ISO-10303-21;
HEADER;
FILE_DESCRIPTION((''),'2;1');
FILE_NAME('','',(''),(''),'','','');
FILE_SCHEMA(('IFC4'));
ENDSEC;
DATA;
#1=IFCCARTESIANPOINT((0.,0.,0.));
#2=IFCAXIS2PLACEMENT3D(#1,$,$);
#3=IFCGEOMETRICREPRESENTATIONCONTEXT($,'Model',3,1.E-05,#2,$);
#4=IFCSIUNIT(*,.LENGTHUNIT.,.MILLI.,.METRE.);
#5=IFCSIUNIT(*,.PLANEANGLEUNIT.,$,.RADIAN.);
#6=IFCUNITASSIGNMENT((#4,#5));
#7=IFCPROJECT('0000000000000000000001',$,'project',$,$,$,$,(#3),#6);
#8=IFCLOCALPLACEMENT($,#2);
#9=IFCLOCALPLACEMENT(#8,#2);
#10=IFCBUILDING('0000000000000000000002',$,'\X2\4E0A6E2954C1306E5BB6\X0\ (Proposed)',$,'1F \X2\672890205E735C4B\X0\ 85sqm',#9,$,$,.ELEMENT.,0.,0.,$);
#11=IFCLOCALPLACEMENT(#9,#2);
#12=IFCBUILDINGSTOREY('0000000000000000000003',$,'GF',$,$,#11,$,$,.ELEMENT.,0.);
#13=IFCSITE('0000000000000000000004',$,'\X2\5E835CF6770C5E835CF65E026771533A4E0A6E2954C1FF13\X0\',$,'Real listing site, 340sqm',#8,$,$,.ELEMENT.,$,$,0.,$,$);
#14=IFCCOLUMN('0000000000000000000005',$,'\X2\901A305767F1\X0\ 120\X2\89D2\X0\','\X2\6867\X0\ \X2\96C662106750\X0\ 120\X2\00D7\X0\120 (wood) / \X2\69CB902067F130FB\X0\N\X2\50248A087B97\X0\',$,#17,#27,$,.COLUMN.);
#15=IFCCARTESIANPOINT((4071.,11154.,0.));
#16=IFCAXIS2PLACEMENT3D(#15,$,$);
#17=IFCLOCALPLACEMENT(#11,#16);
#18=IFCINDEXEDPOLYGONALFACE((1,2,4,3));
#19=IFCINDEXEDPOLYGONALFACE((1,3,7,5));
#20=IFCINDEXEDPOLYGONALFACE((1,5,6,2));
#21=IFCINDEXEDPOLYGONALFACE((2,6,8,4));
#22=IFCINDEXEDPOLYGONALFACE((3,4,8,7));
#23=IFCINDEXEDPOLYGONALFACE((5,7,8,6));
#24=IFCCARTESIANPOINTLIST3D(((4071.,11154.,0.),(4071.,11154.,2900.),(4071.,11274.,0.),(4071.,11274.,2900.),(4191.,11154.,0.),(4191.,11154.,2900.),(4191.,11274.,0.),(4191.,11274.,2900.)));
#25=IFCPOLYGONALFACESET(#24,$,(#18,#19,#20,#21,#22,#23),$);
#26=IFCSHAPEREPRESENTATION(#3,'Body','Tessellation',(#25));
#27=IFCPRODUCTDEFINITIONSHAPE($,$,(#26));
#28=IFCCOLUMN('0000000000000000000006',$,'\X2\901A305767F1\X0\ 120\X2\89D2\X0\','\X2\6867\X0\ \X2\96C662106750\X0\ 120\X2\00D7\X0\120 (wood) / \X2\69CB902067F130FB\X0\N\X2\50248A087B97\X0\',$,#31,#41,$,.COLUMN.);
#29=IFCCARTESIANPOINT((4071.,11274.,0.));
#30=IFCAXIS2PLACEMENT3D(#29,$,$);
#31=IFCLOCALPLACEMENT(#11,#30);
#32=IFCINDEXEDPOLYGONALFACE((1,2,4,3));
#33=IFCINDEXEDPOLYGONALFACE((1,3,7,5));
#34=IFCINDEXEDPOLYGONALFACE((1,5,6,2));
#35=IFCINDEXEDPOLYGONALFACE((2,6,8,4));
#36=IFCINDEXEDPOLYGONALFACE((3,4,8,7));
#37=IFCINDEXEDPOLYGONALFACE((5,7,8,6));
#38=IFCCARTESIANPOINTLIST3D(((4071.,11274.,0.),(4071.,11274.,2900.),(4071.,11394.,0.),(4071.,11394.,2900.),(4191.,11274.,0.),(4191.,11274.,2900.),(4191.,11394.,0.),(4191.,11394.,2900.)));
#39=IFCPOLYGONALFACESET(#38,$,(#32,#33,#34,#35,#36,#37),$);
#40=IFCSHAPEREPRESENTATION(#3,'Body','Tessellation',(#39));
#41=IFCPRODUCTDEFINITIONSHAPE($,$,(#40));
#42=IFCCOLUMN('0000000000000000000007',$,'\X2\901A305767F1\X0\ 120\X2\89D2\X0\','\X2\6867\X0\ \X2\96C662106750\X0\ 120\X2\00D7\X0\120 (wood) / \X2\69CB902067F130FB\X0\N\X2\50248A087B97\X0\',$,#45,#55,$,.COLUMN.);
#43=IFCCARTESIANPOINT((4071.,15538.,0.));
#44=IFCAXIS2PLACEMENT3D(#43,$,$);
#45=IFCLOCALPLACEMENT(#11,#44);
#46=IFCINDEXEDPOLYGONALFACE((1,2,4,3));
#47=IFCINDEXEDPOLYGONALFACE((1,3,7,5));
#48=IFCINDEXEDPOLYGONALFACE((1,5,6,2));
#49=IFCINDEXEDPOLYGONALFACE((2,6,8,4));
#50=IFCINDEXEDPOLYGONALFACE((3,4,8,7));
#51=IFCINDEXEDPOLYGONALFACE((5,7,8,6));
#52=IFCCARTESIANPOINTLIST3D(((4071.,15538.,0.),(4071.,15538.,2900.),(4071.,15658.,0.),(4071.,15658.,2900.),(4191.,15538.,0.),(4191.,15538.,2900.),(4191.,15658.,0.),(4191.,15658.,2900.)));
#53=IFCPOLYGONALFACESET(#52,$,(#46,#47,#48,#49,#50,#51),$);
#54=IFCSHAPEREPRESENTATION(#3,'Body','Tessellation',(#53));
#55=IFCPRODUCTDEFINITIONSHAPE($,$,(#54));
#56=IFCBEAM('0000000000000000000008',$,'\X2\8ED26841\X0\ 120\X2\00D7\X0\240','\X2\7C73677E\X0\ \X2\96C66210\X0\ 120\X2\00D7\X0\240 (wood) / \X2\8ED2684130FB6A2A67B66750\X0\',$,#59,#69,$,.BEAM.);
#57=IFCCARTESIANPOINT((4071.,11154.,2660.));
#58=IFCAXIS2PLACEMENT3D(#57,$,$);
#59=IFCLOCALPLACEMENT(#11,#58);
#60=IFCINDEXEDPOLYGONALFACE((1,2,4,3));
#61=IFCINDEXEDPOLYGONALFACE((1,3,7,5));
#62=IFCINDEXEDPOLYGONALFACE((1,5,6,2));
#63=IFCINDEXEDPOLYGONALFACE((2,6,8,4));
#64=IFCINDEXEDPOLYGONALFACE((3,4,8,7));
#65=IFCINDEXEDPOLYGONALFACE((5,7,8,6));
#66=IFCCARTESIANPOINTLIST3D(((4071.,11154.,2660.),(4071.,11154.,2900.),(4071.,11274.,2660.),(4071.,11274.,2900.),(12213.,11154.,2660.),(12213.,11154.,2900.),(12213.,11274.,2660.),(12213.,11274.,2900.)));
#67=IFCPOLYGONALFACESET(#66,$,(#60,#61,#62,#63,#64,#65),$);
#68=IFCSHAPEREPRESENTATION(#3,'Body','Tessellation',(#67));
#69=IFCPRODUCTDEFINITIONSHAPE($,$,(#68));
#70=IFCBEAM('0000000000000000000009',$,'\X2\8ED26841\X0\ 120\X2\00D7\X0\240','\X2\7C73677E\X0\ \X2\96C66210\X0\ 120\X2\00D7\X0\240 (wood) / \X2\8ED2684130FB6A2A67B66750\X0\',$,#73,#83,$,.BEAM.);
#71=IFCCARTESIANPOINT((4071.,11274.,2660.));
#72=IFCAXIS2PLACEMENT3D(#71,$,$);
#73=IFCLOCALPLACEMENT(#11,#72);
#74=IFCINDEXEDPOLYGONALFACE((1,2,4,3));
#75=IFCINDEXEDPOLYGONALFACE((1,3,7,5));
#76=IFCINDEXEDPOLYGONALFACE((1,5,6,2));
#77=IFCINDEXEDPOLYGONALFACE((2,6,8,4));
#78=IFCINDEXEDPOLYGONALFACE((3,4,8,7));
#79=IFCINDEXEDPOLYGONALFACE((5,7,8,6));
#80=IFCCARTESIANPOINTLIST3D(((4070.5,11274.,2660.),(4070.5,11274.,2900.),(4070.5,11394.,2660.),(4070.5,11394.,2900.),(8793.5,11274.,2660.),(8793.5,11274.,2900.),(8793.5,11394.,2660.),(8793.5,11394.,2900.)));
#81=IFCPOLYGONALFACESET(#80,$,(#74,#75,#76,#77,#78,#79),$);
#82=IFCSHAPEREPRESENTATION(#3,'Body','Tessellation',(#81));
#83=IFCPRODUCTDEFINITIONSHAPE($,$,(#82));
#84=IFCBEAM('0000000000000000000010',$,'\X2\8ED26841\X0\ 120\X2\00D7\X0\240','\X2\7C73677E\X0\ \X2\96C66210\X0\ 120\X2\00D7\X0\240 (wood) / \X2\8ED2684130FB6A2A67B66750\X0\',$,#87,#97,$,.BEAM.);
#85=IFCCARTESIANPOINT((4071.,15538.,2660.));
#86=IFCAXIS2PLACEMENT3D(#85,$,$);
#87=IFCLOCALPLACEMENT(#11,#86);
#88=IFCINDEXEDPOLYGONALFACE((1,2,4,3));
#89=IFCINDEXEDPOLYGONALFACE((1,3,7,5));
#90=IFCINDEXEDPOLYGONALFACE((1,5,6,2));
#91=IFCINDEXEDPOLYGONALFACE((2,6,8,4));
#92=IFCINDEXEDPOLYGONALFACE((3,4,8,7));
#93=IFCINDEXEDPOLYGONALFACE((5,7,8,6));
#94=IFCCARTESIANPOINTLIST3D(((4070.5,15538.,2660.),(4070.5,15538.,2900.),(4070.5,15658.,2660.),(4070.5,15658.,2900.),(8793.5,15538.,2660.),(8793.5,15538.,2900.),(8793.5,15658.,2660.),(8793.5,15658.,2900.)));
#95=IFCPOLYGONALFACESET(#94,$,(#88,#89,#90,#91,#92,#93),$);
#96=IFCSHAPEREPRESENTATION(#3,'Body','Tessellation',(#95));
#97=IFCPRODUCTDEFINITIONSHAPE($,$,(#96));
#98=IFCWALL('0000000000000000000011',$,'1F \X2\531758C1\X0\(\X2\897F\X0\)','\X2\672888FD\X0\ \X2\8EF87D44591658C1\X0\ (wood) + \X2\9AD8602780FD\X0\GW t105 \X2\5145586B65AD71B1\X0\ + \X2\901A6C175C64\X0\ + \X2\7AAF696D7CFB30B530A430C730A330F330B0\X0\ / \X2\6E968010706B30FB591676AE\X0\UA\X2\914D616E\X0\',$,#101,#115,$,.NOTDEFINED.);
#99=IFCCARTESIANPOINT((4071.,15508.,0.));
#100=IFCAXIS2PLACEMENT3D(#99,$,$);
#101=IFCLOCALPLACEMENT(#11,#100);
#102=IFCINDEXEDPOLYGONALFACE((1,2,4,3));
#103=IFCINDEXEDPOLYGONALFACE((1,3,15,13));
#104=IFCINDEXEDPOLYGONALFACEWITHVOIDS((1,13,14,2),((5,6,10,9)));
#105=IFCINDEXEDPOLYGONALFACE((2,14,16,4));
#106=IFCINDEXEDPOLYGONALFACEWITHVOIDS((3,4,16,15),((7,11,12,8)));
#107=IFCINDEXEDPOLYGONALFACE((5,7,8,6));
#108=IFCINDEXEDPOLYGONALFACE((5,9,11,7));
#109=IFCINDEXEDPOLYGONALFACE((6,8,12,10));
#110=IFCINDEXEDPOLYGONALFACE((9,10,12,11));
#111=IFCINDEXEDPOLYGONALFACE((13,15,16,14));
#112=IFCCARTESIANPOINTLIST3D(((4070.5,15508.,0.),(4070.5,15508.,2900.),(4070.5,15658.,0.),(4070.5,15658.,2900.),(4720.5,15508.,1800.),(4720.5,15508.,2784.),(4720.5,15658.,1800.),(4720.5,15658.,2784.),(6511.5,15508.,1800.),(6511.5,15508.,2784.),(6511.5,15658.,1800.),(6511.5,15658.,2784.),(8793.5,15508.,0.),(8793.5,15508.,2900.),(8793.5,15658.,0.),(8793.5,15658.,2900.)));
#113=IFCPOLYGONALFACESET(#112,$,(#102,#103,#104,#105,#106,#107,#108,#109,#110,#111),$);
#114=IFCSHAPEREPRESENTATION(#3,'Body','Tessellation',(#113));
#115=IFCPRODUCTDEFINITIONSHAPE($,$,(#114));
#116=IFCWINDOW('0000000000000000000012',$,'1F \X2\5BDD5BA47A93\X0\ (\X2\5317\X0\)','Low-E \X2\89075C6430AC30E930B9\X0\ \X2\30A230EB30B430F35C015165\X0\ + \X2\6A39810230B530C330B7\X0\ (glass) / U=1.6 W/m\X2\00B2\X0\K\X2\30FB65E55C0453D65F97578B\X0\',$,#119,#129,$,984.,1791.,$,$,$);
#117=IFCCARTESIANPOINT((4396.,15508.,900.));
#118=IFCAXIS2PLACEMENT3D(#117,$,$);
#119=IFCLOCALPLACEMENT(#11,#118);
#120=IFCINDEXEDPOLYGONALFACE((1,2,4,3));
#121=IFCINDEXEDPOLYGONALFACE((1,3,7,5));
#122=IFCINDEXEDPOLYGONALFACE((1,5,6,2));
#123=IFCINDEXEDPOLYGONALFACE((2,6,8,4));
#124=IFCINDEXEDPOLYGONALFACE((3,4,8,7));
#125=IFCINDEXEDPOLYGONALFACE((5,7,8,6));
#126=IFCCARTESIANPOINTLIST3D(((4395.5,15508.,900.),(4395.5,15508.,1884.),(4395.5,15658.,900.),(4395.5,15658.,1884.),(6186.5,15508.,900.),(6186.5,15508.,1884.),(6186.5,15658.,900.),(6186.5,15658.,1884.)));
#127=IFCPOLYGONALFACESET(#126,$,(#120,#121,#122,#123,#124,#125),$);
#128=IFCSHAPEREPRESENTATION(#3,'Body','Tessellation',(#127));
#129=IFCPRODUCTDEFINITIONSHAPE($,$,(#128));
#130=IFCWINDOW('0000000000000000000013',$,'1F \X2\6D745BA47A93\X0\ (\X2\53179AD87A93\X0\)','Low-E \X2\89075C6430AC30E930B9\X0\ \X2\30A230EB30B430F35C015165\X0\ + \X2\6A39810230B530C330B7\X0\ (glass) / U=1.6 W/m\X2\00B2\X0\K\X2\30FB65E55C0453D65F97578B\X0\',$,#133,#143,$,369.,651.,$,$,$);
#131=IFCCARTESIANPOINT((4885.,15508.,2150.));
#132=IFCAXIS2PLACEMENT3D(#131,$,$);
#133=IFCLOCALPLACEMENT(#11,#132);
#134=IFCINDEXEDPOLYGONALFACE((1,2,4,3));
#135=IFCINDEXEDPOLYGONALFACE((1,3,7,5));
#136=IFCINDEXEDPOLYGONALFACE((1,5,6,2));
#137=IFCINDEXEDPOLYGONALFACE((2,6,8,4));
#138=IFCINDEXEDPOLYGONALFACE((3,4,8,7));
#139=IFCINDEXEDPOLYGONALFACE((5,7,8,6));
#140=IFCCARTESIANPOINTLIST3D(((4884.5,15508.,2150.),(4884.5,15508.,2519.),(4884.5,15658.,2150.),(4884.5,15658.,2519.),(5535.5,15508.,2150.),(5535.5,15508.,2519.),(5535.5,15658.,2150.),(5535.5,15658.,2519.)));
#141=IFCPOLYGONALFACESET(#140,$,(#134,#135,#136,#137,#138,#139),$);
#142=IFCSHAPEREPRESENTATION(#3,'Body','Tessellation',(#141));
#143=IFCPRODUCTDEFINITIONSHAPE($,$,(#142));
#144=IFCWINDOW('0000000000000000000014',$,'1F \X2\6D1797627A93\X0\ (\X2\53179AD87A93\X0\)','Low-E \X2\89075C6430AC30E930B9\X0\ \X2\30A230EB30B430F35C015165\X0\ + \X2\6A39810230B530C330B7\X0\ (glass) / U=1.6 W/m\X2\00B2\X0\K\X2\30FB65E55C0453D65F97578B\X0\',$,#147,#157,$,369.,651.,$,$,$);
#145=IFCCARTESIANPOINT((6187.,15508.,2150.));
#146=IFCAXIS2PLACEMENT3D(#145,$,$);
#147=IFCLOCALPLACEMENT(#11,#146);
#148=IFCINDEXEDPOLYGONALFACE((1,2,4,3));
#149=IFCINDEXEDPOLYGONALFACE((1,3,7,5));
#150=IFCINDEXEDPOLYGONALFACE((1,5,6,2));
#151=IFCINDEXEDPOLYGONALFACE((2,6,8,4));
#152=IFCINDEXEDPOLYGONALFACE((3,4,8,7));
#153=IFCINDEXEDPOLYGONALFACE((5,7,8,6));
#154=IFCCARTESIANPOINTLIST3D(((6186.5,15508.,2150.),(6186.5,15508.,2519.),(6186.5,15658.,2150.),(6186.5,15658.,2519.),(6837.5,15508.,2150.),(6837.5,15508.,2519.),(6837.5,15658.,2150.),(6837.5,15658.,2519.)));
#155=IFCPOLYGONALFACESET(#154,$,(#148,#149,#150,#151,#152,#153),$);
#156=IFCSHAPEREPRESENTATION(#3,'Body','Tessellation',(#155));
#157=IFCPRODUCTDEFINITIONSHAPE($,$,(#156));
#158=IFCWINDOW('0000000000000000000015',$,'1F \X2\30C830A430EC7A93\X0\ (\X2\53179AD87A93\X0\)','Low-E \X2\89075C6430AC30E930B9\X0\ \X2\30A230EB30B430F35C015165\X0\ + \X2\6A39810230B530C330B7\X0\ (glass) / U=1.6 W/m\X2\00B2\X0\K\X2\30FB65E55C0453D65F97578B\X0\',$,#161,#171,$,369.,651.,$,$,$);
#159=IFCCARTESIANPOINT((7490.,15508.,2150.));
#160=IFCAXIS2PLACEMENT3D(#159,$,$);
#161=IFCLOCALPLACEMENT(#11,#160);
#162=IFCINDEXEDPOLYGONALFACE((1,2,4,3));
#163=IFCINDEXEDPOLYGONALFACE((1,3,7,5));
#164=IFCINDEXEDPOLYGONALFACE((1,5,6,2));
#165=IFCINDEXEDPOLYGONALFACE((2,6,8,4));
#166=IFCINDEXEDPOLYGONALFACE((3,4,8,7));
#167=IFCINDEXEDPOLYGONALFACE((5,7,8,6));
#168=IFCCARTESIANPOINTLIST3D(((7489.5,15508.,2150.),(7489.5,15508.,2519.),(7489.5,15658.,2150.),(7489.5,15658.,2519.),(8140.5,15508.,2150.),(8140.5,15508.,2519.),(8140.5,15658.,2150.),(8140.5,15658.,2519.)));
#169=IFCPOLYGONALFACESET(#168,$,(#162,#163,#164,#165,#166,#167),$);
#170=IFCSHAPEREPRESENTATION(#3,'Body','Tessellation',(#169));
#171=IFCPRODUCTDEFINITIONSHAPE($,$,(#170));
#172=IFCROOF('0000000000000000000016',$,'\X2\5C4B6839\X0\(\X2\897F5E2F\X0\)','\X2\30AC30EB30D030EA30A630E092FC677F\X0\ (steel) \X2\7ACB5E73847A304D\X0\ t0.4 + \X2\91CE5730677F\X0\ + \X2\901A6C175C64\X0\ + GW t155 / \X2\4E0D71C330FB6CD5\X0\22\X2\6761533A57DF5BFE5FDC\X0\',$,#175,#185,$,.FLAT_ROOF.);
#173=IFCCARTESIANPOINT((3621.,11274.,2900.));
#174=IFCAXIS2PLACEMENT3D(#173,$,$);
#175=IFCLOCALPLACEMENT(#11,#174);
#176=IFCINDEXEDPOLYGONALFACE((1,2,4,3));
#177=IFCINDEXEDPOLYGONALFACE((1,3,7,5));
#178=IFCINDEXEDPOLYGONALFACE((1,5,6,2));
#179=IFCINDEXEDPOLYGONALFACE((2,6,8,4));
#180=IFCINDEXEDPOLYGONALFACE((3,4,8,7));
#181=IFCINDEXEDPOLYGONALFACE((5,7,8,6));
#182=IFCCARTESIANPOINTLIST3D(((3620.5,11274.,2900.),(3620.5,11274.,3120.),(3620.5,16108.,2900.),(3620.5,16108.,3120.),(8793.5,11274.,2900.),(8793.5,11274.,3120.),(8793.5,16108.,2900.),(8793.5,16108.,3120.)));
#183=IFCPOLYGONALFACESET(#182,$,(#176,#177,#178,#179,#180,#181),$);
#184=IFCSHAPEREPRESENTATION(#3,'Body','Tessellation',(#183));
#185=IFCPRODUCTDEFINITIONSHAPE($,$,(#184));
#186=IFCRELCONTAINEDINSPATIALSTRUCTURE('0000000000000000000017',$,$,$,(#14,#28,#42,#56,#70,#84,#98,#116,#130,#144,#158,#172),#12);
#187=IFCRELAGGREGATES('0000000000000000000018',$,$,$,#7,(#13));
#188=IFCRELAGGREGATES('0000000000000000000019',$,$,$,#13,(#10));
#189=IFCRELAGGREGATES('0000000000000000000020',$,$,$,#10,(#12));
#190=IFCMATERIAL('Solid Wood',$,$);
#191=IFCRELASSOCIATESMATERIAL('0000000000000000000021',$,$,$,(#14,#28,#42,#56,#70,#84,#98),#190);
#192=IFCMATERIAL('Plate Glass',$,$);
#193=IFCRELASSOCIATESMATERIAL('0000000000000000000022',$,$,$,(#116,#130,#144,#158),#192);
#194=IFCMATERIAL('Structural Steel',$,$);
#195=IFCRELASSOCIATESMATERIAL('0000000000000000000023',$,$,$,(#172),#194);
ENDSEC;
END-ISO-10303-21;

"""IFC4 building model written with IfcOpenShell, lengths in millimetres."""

from ifc_helpers import new_model, si_unit, frame, frame_2d, origin, place, context, project, spatial, rectangle, extrude, material, element, fill, save


model = new_model("IFC4")

# Units and contexts
model_context = context("Model", 3, precision=1e-05, world=origin())
ifc_project = project(units=[si_unit("LENGTHUNIT", "METRE", prefix="MILLI"), si_unit("PLANEANGLEUNIT", "RADIAN")], contexts=[model_context])

# Site, building, storey
site_placement = place(None, origin())
site = spatial("IfcSite", under=ifc_project, at=site_placement, Name="広島県広島市東区上温品３", ObjectType="Real listing site, 340sqm", CompositionType="ELEMENT", RefElevation=0.0)
building_placement = place(site_placement, origin())
building = spatial("IfcBuilding", under=site, at=building_placement, Name="上温品の家 (Proposed)", ObjectType="1F 木造平屋 85sqm", CompositionType="ELEMENT", ElevationOfRefHeight=0.0, ElevationOfTerrain=0.0)
storey_placement = place(building_placement, origin())
storey = spatial("IfcBuildingStorey", under=building, at=storey_placement, Name="GF", CompositionType="ELEMENT", Elevation=0.0)

# Columns
ifc_material_1 = material(Name="Solid Wood")
column_1_placement = place(storey_placement, frame((4071.0, 11154.0, 0.0)))
element("IfcColumn", 1, at=column_1_placement, inside=storey, material=ifc_material_1, Name="通し柱 120角", Description="桧 集成材 120×120 (wood) / 構造柱・N値計算", PredefinedType="COLUMN", context=model_context, shape_type="SweptSolid", body=[
    extrude(rectangle(XDim=120.0, YDim=120.0, at=frame_2d((60.0, 60.0))), frame((4071.0, 11154.0, 0.0)), (0.0, 0.0, 1.0), 2900.0),
])
column_2_placement = place(storey_placement, frame((4071.0, 11274.0, 0.0)))
element("IfcColumn", 2, at=column_2_placement, inside=storey, material=ifc_material_1, Name="通し柱 120角", Description="桧 集成材 120×120 (wood) / 構造柱・N値計算", PredefinedType="COLUMN", context=model_context, shape_type="SweptSolid", body=[
    extrude(rectangle(XDim=120.0, YDim=120.0, at=frame_2d((60.0, 60.0))), frame((4071.0, 11274.0, 0.0)), (0.0, 0.0, 1.0), 2900.0),
])
column_3_placement = place(storey_placement, frame((4071.0, 15538.0, 0.0)))
element("IfcColumn", 3, at=column_3_placement, inside=storey, material=ifc_material_1, Name="通し柱 120角", Description="桧 集成材 120×120 (wood) / 構造柱・N値計算", PredefinedType="COLUMN", context=model_context, shape_type="SweptSolid", body=[
    extrude(rectangle(XDim=120.0, YDim=120.0, at=frame_2d((60.0, 60.0))), frame((4071.0, 15538.0, 0.0)), (0.0, 0.0, 1.0), 2900.0),
])

# Beams
beam_1_placement = place(storey_placement, frame((4071.0, 11154.0, 2660.0)))
element("IfcBeam", 4, at=beam_1_placement, inside=storey, material=ifc_material_1, Name="軒桁 120×240", Description="米松 集成 120×240 (wood) / 軒桁・横架材", PredefinedType="BEAM", context=model_context, shape_type="SweptSolid", body=[
    extrude(rectangle(XDim=8142.0, YDim=120.0, at=frame_2d((4071.0, 60.0))), frame((4071.0, 11154.0, 2660.0)), (0.0, 0.0, 1.0), 240.0),
])
beam_2_placement = place(storey_placement, frame((4071.0, 11274.0, 2660.0)))
element("IfcBeam", 5, at=beam_2_placement, inside=storey, material=ifc_material_1, Name="軒桁 120×240", Description="米松 集成 120×240 (wood) / 軒桁・横架材", PredefinedType="BEAM", context=model_context, shape_type="SweptSolid", body=[
    extrude(rectangle(XDim=4723.0, YDim=120.0, at=frame_2d((2361.0, 60.0))), frame((4071.0, 11274.0, 2660.0)), (0.0, 0.0, 1.0), 240.0),
])
beam_3_placement = place(storey_placement, frame((4071.0, 15538.0, 2660.0)))
element("IfcBeam", 6, at=beam_3_placement, inside=storey, material=ifc_material_1, Name="軒桁 120×240", Description="米松 集成 120×240 (wood) / 軒桁・横架材", PredefinedType="BEAM", context=model_context, shape_type="SweptSolid", body=[
    extrude(rectangle(XDim=4723.0, YDim=120.0, at=frame_2d((2361.0, 60.0))), frame((4071.0, 15538.0, 2660.0)), (0.0, 0.0, 1.0), 240.0),
])

# Wall, openings, windows
wall_1_placement = place(storey_placement, frame((4071.0, 15508.0, 0.0)))
wall_1 = element("IfcWall", 7, at=wall_1_placement, inside=storey, material=ifc_material_1, Name="1F 北壁(西)", Description="木製 軸組外壁 (wood) + 高性能GW t105 充填断熱 + 通気層 + 窯業系サイディング / 準耐火・外皮UA配慮", PredefinedType="NOTDEFINED", context=model_context, shape_type="SweptSolid", body=[
    extrude(rectangle(XDim=4723.0, YDim=150.0, at=frame_2d((2361.0, 75.0))), frame((4071.0, 15508.0, 0.0)), (0.0, 0.0, 1.0), 2900.0),
])
opening_1_placement = place(storey_placement, frame((4396.0, 15508.0, 900.0)))
opening_1 = element("IfcOpeningElement", 8, at=opening_1_placement, cuts=wall_1, PredefinedType="NOTDEFINED", context=model_context, shape_type="SweptSolid", body=[
    extrude(rectangle(XDim=1791.0, YDim=150.0, at=frame_2d((895.0, 75.0))), frame((4396.0, 15508.0, 900.0)), (0.0, 0.0, 1.0), 984.0),
])
opening_2_placement = place(storey_placement, frame((4885.0, 15508.0, 2150.0)))
opening_2 = element("IfcOpeningElement", 9, at=opening_2_placement, cuts=wall_1, PredefinedType="NOTDEFINED", context=model_context, shape_type="SweptSolid", body=[
    extrude(rectangle(XDim=651.0, YDim=150.0, at=frame_2d((325.0, 75.0))), frame((4885.0, 15508.0, 2150.0)), (0.0, 0.0, 1.0), 369.0),
])
opening_3_placement = place(storey_placement, frame((6187.0, 15508.0, 2150.0)))
opening_3 = element("IfcOpeningElement", 10, at=opening_3_placement, cuts=wall_1, PredefinedType="NOTDEFINED", context=model_context, shape_type="SweptSolid", body=[
    extrude(rectangle(XDim=651.0, YDim=150.0, at=frame_2d((325.0, 75.0))), frame((6187.0, 15508.0, 2150.0)), (0.0, 0.0, 1.0), 369.0),
])
opening_4_placement = place(storey_placement, frame((7490.0, 15508.0, 2150.0)))
opening_4 = element("IfcOpeningElement", 11, at=opening_4_placement, cuts=wall_1, PredefinedType="NOTDEFINED", context=model_context, shape_type="SweptSolid", body=[
    extrude(rectangle(XDim=651.0, YDim=150.0, at=frame_2d((325.0, 75.0))), frame((7490.0, 15508.0, 2150.0)), (0.0, 0.0, 1.0), 369.0),
])
ifc_material_2 = material(Name="Plate Glass")
window_1_placement = place(storey_placement, frame((4396.0, 15508.0, 900.0)))
window_1 = element("IfcWindow", 12, at=window_1_placement, inside=storey, material=ifc_material_2, Name="1F 寝室窓 (北)", Description="Low-E 複層ガラス アルゴン封入 + 樹脂サッシ (glass) / U=1.6 W/m²K・日射取得型", OverallHeight=984.0, OverallWidth=1791.0, context=model_context, shape_type="SweptSolid", body=[
    extrude(rectangle(XDim=1791.0, YDim=150.0, at=frame_2d((895.0, 75.0))), frame((4396.0, 15508.0, 900.0)), (0.0, 0.0, 1.0), 984.0),
])
fill(opening_1, window_1)
window_2_placement = place(storey_placement, frame((4885.0, 15508.0, 2150.0)))
window_2 = element("IfcWindow", 13, at=window_2_placement, inside=storey, material=ifc_material_2, Name="1F 浴室窓 (北高窓)", Description="Low-E 複層ガラス アルゴン封入 + 樹脂サッシ (glass) / U=1.6 W/m²K・日射取得型", OverallHeight=369.0, OverallWidth=651.0, context=model_context, shape_type="SweptSolid", body=[
    extrude(rectangle(XDim=651.0, YDim=150.0, at=frame_2d((325.0, 75.0))), frame((4885.0, 15508.0, 2150.0)), (0.0, 0.0, 1.0), 369.0),
])
fill(opening_2, window_2)
window_3_placement = place(storey_placement, frame((6187.0, 15508.0, 2150.0)))
window_3 = element("IfcWindow", 14, at=window_3_placement, inside=storey, material=ifc_material_2, Name="1F 洗面窓 (北高窓)", Description="Low-E 複層ガラス アルゴン封入 + 樹脂サッシ (glass) / U=1.6 W/m²K・日射取得型", OverallHeight=369.0, OverallWidth=651.0, context=model_context, shape_type="SweptSolid", body=[
    extrude(rectangle(XDim=651.0, YDim=150.0, at=frame_2d((325.0, 75.0))), frame((6187.0, 15508.0, 2150.0)), (0.0, 0.0, 1.0), 369.0),
])
fill(opening_3, window_3)
window_4_placement = place(storey_placement, frame((7490.0, 15508.0, 2150.0)))
window_4 = element("IfcWindow", 15, at=window_4_placement, inside=storey, material=ifc_material_2, Name="1F トイレ窓 (北高窓)", Description="Low-E 複層ガラス アルゴン封入 + 樹脂サッシ (glass) / U=1.6 W/m²K・日射取得型", OverallHeight=369.0, OverallWidth=651.0, context=model_context, shape_type="SweptSolid", body=[
    extrude(rectangle(XDim=651.0, YDim=150.0, at=frame_2d((325.0, 75.0))), frame((7490.0, 15508.0, 2150.0)), (0.0, 0.0, 1.0), 369.0),
])
fill(opening_4, window_4)

# Roof
ifc_material_3 = material(Name="Structural Steel")
roof_placement = place(storey_placement, frame((3621.0, 11274.0, 2900.0)))
element("IfcRoof", 16, at=roof_placement, inside=storey, material=ifc_material_3, Name="屋根(西帯)", Description="ガルバリウム鋼板 (steel) 立平葺き t0.4 + 野地板 + 通気層 + GW t155 / 不燃・法22条区域対応", PredefinedType="FLAT_ROOF", context=model_context, shape_type="SweptSolid", body=[
    extrude(rectangle(XDim=5173.0, YDim=4834.0, at=frame_2d((2586.0, 2417.0))), frame((3621.0, 11274.0, 2900.0)), (0.0, 0.0, 1.0), 220.0),
])

save(model, "model.ifc")
